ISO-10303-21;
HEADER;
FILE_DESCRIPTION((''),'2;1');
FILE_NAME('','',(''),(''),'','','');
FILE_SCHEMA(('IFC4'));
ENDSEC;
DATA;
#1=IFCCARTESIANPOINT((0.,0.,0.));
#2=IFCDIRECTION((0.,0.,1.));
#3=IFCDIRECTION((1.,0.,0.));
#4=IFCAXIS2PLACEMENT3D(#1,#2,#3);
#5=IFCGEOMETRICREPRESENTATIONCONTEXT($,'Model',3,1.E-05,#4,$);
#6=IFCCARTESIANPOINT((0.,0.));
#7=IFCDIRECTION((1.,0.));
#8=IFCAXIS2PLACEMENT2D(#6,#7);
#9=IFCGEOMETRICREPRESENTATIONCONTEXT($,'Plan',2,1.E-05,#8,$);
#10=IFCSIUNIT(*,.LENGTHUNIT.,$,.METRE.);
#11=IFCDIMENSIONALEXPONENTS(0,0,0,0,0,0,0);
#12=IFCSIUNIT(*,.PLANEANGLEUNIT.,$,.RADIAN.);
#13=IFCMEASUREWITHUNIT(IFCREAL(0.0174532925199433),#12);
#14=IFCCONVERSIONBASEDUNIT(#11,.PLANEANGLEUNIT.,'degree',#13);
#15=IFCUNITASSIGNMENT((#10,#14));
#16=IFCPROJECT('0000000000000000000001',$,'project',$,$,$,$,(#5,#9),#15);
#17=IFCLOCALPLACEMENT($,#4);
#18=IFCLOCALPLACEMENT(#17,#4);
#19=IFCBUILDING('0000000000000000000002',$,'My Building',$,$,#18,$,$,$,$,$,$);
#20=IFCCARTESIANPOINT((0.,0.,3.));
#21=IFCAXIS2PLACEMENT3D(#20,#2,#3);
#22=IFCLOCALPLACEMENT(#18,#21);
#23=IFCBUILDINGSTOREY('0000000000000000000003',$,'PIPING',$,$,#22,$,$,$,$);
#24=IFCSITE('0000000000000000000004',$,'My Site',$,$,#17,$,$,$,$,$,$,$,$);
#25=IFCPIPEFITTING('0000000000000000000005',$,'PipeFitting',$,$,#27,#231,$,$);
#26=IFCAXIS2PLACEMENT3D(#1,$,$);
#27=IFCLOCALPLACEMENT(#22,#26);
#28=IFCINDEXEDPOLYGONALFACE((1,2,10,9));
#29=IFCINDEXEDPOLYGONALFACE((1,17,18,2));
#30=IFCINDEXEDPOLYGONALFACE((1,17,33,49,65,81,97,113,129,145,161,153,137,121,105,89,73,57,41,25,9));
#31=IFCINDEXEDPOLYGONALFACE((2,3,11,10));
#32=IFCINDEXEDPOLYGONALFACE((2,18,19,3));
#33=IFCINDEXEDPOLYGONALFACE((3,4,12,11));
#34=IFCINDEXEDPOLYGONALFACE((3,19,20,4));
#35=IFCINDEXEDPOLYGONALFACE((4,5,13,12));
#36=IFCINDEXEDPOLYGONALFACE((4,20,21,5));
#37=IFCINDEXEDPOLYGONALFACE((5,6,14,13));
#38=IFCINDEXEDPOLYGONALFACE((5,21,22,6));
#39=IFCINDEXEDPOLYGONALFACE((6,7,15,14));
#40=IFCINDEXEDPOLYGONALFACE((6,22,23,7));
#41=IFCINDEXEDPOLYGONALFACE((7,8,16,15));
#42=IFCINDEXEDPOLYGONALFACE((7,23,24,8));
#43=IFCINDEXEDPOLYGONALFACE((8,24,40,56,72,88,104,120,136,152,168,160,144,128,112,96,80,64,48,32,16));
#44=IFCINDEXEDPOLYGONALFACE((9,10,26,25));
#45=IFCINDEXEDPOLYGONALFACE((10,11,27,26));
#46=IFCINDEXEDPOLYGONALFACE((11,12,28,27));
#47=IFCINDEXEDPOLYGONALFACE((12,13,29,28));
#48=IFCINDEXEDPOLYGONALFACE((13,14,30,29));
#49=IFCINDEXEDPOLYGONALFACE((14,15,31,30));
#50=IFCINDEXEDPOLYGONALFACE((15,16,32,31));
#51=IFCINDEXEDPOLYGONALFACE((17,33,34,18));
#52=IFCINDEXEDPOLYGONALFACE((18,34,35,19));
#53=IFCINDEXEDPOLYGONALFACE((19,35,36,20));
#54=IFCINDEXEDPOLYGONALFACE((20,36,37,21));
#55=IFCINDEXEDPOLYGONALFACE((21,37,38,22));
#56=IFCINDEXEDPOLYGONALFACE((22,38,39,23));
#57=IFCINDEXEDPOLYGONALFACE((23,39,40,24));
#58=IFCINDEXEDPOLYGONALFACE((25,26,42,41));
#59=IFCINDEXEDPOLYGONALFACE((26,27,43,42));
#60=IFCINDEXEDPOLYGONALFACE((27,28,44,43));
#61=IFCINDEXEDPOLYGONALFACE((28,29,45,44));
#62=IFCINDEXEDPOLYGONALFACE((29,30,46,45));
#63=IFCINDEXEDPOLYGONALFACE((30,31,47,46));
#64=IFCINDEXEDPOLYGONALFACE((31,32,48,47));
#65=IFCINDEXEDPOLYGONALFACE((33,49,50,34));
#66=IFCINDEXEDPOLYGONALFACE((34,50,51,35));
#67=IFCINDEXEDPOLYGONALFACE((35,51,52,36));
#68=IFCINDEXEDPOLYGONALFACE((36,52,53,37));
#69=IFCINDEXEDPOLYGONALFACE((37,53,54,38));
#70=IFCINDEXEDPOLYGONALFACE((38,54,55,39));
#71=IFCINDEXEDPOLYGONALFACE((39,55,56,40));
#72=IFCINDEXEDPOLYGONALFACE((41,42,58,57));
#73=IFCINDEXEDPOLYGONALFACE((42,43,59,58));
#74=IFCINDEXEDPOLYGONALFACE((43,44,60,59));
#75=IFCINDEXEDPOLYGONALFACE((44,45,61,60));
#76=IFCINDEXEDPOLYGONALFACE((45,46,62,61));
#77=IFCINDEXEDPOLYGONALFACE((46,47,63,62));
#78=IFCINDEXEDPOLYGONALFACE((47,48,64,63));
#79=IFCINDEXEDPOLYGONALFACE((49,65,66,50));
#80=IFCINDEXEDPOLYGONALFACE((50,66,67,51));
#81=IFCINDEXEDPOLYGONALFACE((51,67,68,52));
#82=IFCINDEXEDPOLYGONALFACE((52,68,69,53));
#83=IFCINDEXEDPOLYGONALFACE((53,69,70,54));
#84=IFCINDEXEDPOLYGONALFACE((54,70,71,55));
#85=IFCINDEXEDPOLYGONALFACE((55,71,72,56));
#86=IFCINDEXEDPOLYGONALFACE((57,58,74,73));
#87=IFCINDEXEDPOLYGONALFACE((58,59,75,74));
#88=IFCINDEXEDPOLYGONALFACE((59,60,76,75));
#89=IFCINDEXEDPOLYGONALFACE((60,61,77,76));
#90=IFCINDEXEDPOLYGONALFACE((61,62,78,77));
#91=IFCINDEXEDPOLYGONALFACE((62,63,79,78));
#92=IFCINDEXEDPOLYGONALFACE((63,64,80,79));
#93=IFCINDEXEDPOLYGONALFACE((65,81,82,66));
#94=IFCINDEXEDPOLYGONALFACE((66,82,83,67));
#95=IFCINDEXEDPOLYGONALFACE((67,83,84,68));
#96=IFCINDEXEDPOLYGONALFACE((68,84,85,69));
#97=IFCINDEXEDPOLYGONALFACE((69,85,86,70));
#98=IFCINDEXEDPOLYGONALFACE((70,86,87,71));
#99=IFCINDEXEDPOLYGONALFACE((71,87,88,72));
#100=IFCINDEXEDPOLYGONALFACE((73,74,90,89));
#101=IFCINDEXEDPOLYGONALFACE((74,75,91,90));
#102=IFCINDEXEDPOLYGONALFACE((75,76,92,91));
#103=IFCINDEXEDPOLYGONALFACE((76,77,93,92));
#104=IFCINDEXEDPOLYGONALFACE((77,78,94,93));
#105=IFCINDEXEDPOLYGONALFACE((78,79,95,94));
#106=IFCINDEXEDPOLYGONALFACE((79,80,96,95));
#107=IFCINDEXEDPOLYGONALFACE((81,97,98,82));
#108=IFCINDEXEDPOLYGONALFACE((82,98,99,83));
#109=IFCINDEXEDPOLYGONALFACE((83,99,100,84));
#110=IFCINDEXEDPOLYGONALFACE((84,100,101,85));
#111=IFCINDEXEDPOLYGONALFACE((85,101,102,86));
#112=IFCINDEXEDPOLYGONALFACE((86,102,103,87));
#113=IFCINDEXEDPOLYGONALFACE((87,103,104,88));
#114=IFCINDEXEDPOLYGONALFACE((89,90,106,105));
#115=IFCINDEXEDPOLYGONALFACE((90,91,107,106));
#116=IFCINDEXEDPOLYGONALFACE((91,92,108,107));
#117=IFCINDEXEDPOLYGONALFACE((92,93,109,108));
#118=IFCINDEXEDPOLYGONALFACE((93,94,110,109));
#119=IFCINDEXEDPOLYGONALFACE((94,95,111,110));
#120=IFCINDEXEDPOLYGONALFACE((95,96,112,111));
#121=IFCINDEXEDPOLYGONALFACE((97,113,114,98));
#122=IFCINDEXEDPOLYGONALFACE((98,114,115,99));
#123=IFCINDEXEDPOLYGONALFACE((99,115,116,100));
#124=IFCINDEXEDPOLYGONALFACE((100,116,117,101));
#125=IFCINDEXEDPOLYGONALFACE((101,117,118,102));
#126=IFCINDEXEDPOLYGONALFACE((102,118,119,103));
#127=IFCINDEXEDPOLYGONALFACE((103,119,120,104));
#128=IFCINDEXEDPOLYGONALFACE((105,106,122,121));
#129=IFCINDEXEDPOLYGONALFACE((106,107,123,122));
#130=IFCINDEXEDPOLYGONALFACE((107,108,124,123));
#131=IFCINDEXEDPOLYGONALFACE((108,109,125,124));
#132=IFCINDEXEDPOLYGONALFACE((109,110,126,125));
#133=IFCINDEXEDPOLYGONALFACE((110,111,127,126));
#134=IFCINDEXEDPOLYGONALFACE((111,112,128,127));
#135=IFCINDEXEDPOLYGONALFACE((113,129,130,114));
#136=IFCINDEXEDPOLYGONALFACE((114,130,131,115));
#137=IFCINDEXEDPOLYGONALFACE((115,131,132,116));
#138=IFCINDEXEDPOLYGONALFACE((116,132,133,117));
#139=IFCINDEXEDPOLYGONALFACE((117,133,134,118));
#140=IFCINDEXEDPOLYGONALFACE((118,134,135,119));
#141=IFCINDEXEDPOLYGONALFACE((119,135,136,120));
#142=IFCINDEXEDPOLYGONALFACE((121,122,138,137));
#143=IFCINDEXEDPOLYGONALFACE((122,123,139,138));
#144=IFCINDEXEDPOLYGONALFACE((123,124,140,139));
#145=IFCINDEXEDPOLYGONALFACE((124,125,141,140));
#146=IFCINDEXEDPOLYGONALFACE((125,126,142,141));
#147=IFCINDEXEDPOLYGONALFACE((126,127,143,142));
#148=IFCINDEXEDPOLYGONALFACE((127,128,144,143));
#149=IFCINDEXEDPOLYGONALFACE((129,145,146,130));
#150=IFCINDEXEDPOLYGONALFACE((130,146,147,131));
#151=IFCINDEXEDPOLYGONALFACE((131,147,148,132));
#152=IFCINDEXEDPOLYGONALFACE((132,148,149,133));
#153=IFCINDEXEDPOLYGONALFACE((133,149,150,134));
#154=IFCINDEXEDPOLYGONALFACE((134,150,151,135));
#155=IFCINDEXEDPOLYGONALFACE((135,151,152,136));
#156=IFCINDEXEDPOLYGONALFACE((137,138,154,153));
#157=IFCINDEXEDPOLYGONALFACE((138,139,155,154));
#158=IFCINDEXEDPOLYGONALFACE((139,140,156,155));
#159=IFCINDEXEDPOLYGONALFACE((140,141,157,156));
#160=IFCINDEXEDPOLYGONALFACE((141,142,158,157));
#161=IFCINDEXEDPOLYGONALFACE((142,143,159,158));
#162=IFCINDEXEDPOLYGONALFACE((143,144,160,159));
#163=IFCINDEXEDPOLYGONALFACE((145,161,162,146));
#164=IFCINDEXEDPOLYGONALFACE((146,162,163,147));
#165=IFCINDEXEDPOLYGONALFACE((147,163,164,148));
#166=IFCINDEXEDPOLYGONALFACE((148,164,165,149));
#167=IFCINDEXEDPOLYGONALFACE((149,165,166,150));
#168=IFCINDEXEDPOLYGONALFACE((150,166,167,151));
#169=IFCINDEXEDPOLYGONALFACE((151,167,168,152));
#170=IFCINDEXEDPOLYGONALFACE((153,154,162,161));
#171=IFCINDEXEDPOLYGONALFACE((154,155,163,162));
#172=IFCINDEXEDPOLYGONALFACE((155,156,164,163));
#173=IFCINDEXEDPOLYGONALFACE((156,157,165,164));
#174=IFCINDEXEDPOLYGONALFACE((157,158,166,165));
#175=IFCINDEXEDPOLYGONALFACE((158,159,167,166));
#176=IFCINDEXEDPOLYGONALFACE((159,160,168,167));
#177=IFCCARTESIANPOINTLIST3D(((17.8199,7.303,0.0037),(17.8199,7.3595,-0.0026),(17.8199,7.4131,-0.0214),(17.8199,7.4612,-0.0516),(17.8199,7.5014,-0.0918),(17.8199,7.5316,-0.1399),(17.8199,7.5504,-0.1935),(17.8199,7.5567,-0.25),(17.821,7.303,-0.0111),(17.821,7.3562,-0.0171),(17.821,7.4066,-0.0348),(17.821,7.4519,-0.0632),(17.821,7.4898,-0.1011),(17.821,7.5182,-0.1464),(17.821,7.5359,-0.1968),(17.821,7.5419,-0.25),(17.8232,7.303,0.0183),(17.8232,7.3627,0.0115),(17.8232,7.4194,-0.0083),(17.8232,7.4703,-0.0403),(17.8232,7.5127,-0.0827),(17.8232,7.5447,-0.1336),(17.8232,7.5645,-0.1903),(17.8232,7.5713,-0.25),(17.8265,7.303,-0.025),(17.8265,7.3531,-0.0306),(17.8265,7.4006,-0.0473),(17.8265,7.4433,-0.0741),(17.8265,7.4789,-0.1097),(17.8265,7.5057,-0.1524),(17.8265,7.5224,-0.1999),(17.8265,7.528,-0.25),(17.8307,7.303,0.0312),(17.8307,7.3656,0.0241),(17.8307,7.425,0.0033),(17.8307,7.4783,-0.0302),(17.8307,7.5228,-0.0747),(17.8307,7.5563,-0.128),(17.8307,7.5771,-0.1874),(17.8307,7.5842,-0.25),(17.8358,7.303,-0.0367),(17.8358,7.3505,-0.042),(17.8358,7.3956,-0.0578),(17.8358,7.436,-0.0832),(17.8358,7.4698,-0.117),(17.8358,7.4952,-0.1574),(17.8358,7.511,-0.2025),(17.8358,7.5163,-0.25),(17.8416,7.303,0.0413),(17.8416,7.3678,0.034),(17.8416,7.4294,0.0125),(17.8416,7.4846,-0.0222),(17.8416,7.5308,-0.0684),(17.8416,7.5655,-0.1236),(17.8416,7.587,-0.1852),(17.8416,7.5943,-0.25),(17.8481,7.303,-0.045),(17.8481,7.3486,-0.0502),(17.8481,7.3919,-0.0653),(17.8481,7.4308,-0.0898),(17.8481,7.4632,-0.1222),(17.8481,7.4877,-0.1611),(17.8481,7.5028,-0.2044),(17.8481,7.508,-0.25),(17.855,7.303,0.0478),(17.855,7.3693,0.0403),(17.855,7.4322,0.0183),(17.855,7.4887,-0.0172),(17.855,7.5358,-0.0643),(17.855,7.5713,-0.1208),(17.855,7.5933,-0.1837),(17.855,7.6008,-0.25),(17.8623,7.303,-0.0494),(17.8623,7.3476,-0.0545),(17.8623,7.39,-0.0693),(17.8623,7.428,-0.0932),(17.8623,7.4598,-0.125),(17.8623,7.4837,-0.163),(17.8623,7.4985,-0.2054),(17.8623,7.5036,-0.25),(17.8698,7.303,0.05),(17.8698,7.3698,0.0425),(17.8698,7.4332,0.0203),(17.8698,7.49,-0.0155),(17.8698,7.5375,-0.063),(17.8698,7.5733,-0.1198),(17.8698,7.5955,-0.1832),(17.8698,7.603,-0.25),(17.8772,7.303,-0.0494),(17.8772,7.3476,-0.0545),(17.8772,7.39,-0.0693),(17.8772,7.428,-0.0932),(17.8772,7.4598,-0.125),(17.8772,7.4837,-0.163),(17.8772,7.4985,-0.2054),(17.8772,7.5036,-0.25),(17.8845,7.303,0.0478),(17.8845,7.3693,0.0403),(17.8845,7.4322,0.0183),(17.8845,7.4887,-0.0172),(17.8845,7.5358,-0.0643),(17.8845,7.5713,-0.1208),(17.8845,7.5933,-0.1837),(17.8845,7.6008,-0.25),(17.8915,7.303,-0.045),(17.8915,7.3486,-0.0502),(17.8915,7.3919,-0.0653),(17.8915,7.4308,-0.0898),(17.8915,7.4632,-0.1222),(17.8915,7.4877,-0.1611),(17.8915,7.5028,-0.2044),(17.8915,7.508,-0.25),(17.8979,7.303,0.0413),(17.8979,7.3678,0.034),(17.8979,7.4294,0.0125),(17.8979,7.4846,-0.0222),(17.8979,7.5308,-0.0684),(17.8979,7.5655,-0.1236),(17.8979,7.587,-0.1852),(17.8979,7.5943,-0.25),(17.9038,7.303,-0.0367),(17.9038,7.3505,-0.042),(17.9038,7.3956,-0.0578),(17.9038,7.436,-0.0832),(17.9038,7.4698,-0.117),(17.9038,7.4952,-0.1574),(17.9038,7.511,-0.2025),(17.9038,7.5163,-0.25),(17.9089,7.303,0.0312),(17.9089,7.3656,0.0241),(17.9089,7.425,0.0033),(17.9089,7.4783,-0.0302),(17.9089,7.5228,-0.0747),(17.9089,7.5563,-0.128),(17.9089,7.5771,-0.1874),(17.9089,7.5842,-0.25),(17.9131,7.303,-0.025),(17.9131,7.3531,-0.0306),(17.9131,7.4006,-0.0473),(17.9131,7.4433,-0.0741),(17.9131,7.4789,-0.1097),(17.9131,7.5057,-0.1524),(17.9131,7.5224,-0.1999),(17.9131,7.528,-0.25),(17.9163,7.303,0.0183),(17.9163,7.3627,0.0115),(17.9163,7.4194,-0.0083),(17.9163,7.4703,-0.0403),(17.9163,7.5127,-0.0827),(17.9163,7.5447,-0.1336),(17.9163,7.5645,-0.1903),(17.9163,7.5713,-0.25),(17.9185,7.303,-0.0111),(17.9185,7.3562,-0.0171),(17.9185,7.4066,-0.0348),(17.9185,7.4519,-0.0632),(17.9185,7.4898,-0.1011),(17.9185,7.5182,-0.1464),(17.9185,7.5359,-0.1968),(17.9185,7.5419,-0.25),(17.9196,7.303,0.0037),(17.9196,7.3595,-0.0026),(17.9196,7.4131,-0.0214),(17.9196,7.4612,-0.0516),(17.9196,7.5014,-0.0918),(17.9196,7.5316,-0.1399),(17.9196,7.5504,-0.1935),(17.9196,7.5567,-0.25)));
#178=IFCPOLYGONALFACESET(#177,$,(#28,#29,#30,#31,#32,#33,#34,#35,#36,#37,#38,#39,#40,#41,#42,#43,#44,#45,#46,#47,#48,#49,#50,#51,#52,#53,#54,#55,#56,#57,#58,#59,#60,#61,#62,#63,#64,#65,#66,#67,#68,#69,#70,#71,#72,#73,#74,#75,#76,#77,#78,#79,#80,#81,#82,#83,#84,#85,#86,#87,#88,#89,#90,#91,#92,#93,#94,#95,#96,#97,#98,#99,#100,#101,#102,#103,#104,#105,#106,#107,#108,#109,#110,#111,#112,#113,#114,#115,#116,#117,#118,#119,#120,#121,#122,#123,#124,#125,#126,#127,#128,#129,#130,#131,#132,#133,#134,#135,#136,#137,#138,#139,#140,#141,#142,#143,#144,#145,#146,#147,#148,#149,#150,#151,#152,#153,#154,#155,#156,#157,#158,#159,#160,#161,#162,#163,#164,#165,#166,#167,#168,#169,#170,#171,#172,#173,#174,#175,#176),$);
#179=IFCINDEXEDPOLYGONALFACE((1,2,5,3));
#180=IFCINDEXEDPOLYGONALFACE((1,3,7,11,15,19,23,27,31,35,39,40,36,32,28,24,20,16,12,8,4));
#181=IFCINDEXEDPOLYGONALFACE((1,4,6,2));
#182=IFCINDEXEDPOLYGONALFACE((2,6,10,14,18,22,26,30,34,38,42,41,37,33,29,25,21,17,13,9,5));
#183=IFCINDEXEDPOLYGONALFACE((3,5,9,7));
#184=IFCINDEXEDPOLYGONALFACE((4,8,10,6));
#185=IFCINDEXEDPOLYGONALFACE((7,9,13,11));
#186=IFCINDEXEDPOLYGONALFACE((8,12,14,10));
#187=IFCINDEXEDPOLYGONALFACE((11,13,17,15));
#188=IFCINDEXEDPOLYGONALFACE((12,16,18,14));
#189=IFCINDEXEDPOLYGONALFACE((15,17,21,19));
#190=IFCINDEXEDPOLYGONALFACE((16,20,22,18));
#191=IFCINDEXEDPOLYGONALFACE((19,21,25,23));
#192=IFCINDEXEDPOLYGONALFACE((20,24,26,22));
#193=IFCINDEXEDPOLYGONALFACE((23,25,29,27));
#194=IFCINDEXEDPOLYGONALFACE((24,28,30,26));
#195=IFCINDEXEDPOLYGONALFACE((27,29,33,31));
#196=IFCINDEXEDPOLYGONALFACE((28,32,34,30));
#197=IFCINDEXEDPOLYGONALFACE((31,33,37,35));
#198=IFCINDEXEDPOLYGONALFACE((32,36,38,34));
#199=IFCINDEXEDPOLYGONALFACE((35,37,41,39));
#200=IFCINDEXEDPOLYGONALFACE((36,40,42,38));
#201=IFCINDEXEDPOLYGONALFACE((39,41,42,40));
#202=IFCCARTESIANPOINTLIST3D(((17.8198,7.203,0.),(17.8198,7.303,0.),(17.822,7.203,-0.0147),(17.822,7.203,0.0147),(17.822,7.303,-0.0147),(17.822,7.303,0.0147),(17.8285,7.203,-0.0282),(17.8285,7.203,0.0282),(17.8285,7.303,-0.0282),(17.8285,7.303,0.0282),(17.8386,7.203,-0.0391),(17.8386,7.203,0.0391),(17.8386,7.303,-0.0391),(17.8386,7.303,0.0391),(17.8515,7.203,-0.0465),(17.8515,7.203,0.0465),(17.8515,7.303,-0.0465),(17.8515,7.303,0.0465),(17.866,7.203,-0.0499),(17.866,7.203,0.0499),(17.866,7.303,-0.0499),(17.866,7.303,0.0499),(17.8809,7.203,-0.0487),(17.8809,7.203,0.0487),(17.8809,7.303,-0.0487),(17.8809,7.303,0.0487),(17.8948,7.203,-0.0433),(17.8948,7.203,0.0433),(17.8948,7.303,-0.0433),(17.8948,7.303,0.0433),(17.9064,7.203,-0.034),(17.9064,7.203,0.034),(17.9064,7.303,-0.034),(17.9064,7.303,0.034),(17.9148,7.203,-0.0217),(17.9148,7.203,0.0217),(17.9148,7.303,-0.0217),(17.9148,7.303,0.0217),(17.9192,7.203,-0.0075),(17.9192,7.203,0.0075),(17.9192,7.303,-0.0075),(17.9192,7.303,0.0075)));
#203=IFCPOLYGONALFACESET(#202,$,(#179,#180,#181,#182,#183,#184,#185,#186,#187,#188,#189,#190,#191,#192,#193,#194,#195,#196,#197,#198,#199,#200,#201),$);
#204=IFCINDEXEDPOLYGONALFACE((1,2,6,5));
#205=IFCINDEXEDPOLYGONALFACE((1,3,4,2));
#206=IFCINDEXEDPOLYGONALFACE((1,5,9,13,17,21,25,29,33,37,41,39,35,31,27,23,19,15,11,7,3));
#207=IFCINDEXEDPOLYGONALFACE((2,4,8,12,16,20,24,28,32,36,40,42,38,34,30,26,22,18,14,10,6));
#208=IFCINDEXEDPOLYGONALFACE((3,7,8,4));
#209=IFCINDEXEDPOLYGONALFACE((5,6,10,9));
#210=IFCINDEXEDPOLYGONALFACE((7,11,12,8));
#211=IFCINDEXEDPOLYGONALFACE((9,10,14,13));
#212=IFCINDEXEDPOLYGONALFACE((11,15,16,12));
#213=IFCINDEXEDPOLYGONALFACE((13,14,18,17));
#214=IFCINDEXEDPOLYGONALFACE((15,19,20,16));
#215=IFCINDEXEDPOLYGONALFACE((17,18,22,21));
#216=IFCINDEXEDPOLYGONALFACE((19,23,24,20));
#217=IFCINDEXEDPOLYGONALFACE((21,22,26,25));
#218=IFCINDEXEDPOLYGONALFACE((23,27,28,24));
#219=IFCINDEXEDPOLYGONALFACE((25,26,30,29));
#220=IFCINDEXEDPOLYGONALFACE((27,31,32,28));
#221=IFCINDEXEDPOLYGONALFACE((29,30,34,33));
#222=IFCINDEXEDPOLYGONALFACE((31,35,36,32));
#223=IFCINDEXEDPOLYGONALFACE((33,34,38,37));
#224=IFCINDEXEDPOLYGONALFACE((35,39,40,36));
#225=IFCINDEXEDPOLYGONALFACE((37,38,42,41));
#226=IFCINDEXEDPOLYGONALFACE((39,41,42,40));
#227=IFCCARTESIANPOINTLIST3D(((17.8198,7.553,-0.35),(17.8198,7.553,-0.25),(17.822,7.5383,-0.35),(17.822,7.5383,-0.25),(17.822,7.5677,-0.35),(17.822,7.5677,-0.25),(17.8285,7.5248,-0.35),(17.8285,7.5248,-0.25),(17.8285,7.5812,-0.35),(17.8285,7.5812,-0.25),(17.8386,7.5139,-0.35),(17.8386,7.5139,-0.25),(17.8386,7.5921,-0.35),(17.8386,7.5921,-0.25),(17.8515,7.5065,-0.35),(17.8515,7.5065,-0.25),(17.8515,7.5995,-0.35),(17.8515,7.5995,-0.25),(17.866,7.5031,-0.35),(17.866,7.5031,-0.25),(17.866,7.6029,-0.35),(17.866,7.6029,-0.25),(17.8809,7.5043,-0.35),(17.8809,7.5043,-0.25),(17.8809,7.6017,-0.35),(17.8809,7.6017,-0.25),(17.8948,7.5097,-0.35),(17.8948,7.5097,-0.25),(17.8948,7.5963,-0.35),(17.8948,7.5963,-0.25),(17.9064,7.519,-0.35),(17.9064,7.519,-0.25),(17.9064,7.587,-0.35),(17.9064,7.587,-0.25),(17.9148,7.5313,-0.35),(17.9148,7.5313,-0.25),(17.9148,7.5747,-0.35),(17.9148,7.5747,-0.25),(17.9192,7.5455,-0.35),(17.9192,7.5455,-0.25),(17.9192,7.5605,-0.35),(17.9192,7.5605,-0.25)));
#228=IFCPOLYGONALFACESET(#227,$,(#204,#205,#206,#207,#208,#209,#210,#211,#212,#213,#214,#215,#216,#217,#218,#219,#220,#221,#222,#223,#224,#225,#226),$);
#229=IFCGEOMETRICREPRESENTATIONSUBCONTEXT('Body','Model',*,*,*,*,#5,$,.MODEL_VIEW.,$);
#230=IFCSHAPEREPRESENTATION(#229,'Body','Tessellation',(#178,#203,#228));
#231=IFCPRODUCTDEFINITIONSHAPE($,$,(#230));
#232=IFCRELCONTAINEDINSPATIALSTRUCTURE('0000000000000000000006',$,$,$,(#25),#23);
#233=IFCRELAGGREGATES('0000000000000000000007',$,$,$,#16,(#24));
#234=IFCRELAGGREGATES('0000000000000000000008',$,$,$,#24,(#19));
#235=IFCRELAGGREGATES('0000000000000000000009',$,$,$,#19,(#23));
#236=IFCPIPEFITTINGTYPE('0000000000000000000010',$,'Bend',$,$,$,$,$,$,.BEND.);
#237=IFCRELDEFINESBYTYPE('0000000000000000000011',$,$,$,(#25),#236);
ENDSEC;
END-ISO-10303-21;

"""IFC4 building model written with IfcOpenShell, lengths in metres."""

from ifc_helpers import new_model, entity, si_unit, converted_unit, frame, origin_with_axes, origin_2d_with_axis, place, context, subcontext, project, spatial, line, indexed_curve, circle, outline, extrude, source, transform, mapped, type_object, type_shapes, element, save


model = new_model("IFC4")

# Units and contexts
model_context = context("Model", 3, precision=1e-05, world=origin_with_axes())
plan_context = context("Plan", 2, precision=1e-05, world=origin_2d_with_axis())
body_context = subcontext(model_context, "Body", "Model", "MODEL_VIEW")
ifc_project = project(units=[si_unit("LENGTHUNIT", "METRE"), converted_unit("PLANEANGLEUNIT", "degree", entity("IfcReal", 0.0174532925199433), si_unit("PLANEANGLEUNIT", "RADIAN"), dimensions=[0, 0, 0, 0, 0, 0, 0])], contexts=[model_context, plan_context])

# Site, building, storey
site_placement = place(None, origin_with_axes())
site = spatial("IfcSite", under=ifc_project, at=site_placement, Name="My Site")
building_placement = place(site_placement, origin_with_axes())
building = spatial("IfcBuilding", under=site, at=building_placement, Name="My Building")
storey_placement = place(building_placement, frame((0.0, 0.0, 3.0), z_axis=(0.0, 0.0, 1.0), x_axis=(1.0, 0.0, 0.0)))
storey = spatial("IfcBuildingStorey", under=building, at=storey_placement, Name="PIPING")

# Shared definitions
pipe_fitting_type = type_object("IfcPipeFittingType", Name="Bend", PredefinedType="BEND")
shared_shape = source(origin_with_axes(), body_context, "Body", "SolidModel", [
    entity("IfcSweptDiskSolid", entity("IfcIndexedPolyCurve", entity("IfcCartesianPointList3D", [[0.0, 0.0, -0.1], [0.0, 0.0732, -0.2768], [0.0, 0.25, -0.35]]), [entity("IfcArcIndex", [1, 2, 3])]), 0.05),
    extrude(circle(Radius=0.05), origin_with_axes(), (0.0, 0.0, -1.0), 0.1),
    extrude(circle(Radius=0.05), frame((0.0, 0.25, -0.35), z_axis=(0.0, 1.0, 0.0), x_axis=(1.0, 0.0, 0.0)), (0.0, 0.0, 1.0), 0.1),
])
type_shapes(pipe_fitting_type, [shared_shape])

# Pipe fitting, opening
pipe_fitting_1_placement = place(storey_placement, frame((17.8698, 7.203, 0.0), z_axis=(0.0, -1.0, 0.0), x_axis=(-1.0, 0.0, 0.0)))
pipe_fitting_1 = element("IfcPipeFitting", 1, at=pipe_fitting_1_placement, inside=storey, type_object=pipe_fitting_type, Name="PipeFitting", context=body_context, shape_type="MappedRepresentation", body=[
    mapped(shared_shape, transform((0.0, 0.0, 0.0), x_axis=(1.0, 0.0, 0.0), y_axis=(0.0, 1.0, 0.0), z_axis=(0.0, 0.0, 1.0), scale=1.0)),
])
opening_1_placement = place(pipe_fitting_1_placement, frame((17.8698, 3.0, 7.203), z_axis=(0.0, -1.0, 0.0), x_axis=(-1.0, 0.0, 0.0)))
element("IfcOpeningElement", 2, at=opening_1_placement, cuts=pipe_fitting_1, PredefinedType="OPENING", context=body_context, shape_type="SweptSolid", body=[
    extrude(outline(indexed_curve([(0.0, 0.0), (0.5, 0.0), (0.5, 0.5), (0.0, 0.5)], segments=[line(1, 2, 3, 4, 1)])), origin_with_axes(), (0.0, 0.0, 1.0), 0.5),
])

save(model, "model.ifc")
